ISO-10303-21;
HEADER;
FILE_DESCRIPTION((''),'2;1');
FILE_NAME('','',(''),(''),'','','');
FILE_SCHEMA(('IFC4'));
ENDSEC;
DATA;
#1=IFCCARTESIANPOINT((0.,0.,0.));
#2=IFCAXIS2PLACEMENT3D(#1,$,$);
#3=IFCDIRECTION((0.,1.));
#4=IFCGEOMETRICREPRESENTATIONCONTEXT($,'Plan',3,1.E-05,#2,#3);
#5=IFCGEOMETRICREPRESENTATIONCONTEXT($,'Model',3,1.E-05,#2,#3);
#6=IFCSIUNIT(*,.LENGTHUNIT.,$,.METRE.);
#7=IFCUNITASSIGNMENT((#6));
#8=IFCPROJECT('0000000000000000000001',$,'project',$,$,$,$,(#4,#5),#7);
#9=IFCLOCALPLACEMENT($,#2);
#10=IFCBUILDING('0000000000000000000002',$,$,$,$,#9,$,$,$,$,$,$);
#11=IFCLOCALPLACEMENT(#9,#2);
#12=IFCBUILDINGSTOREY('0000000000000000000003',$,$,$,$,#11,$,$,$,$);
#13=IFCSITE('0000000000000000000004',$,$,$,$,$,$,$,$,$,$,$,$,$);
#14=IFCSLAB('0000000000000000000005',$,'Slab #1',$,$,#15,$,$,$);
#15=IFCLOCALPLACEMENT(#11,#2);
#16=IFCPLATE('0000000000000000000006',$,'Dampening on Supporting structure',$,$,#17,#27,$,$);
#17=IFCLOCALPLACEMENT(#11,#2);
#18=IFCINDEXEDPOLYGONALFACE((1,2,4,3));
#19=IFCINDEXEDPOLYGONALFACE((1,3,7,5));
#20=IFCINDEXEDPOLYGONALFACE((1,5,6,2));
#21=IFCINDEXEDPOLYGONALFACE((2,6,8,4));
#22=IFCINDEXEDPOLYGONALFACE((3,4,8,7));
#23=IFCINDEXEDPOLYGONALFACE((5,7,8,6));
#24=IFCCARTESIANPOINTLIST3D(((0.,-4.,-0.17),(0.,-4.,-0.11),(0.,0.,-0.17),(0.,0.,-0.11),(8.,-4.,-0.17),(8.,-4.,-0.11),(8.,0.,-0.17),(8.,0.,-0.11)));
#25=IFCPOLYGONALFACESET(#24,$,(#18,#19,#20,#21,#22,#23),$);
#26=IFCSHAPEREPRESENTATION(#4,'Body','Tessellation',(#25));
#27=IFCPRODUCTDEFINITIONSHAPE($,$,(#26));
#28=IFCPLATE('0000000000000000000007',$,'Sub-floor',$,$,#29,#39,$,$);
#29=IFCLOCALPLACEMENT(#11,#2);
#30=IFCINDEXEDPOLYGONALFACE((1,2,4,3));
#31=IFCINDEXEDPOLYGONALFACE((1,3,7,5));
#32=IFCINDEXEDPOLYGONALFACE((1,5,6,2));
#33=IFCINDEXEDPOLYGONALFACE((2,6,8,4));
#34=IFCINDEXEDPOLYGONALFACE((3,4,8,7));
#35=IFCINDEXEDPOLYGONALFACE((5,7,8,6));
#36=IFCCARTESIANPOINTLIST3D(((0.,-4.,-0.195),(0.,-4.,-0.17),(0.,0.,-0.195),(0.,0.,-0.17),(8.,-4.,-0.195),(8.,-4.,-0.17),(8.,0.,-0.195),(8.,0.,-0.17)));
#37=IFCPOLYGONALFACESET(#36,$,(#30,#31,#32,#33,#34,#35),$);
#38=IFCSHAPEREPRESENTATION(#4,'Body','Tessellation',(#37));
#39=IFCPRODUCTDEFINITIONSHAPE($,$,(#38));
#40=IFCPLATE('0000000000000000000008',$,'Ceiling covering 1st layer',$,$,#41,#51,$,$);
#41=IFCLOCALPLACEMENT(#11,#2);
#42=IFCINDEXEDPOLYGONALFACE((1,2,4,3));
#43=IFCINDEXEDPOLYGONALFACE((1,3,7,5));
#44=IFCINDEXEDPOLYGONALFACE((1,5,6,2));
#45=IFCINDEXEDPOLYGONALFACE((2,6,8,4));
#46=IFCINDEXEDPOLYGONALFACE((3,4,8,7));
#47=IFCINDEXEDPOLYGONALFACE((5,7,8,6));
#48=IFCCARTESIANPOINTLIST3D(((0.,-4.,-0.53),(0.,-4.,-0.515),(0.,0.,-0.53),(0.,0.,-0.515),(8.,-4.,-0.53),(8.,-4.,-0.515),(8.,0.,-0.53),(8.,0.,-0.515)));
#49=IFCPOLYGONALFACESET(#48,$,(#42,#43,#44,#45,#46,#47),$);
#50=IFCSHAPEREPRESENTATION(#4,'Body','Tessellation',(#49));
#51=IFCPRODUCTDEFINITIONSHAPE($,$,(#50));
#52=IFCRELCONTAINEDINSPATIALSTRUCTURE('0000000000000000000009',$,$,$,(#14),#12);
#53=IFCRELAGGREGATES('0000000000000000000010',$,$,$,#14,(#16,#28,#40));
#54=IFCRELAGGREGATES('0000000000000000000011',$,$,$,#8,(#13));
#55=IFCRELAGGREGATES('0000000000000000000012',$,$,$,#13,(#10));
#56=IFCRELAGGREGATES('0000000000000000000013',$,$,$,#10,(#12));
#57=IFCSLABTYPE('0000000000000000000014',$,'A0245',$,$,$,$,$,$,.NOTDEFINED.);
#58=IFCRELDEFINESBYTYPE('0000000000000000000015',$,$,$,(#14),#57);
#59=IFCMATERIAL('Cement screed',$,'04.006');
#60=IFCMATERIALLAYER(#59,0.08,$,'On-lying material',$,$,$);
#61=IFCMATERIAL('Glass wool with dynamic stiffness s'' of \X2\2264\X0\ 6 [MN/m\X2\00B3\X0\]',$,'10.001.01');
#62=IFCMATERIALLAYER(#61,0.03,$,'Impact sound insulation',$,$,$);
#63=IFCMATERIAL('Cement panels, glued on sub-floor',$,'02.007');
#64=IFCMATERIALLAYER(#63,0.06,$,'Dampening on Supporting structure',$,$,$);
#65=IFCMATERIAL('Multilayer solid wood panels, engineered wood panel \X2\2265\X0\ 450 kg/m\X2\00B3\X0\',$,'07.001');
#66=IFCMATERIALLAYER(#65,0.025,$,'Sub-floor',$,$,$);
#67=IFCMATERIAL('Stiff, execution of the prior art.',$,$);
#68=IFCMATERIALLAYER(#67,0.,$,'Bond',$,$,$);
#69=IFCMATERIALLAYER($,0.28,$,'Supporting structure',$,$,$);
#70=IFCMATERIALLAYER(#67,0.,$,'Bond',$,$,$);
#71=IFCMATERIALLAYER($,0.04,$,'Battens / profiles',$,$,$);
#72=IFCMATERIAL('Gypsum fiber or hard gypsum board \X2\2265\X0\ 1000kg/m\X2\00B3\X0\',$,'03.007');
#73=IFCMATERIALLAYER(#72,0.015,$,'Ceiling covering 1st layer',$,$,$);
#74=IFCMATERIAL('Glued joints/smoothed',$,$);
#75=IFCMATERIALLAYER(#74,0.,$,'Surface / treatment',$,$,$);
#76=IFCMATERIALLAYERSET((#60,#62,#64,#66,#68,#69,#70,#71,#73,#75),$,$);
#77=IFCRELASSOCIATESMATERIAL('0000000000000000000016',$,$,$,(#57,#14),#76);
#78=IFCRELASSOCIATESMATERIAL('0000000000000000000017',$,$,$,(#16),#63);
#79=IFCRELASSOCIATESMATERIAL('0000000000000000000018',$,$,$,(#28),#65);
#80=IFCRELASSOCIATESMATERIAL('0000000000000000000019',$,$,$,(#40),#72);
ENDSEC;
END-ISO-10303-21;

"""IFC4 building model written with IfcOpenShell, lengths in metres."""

from ifc_helpers import new_model, si_unit, direction, frame, frame_2d, origin, place, context, project, spatial, rectangle, extrude, material, layer, layer_set, type_object, element, aggregate, save


model = new_model("IFC4")

# Units and contexts
plan_context = context("Plan", 3, precision=1e-05, world=origin(), true_north=direction((0.0, 1.0)))
model_context = context("Model", 3, precision=1e-05, world=origin(), true_north=direction((0.0, 1.0)))
ifc_project = project(units=[si_unit("LENGTHUNIT", "METRE")], contexts=[plan_context, model_context])

# Site, building, storey
site = spatial("IfcSite", under=ifc_project)
building_placement = place(None, origin())
building = spatial("IfcBuilding", under=site, at=building_placement)
storey_placement = place(building_placement, origin())
storey = spatial("IfcBuildingStorey", under=building, at=storey_placement)

# Slab, plates
ifc_material_1 = material(Name="Cement screed", Category="04.006")
ifc_layer_1 = layer(ifc_material_1, 0.08, Name="On-lying material")
ifc_material_2 = material(Name="Glass wool with dynamic stiffness s' of ≤ 6 [MN/m³]", Category="10.001.01")
ifc_layer_2 = layer(ifc_material_2, 0.03, Name="Impact sound insulation")
ifc_material_3 = material(Name="Cement panels, glued on sub-floor", Category="02.007")
ifc_layer_3 = layer(ifc_material_3, 0.06, Name="Dampening on Supporting structure")
ifc_material_4 = material(Name="Multilayer solid wood panels, engineered wood panel ≥ 450 kg/m³", Category="07.001")
ifc_layer_4 = layer(ifc_material_4, 0.025, Name="Sub-floor")
ifc_material_5 = material(Name="Stiff, execution of the prior art.")
ifc_layer_5 = layer(ifc_material_5, 0.0, Name="Bond")
ifc_layer_6 = layer(None, 0.28, Name="Supporting structure")
ifc_layer_7 = layer(ifc_material_5, 0.0, Name="Bond")
ifc_layer_8 = layer(None, 0.04, Name="Battens / profiles")
ifc_material_6 = material(Name="Gypsum fiber or hard gypsum board ≥ 1000kg/m³", Category="03.007")
ifc_layer_9 = layer(ifc_material_6, 0.015, Name="Ceiling covering 1st layer")
ifc_material_7 = material(Name="Glued joints/smoothed")
ifc_layer_10 = layer(ifc_material_7, 0.0, Name="Surface / treatment")
ifc_layer_set = layer_set([ifc_layer_1, ifc_layer_2, ifc_layer_3, ifc_layer_4, ifc_layer_5, ifc_layer_6, ifc_layer_7, ifc_layer_8, ifc_layer_9, ifc_layer_10])
slab_type = type_object("IfcSlabType", Name="A0245", PredefinedType="NOTDEFINED", material=ifc_layer_set)
slab_placement = place(None, frame((0.0, 0.0, 0.0), z_axis=(0.0, 0.0, -1.0), x_axis=(1.0, 0.0, 0.0)))
slab = element("IfcSlab", 1, at=slab_placement, inside=storey, type_object=slab_type, material=ifc_layer_set, Name="Slab #1")
plate_1_placement = place(slab_placement, origin())
plate_1 = element("IfcPlate", 2, at=plate_1_placement, material=ifc_material_3, Name="Dampening on Supporting structure", context=plan_context, shape_type="SweptSolid", body=[
    extrude(rectangle(XDim=8.0, YDim=4.0, at=frame_2d((4.0, 2.0), x_axis=(1.0, 0.0))), frame((0.0, 0.0, 0.11), z_axis=(0.0, 0.0, 1.0), x_axis=(1.0, 0.0, 0.0)), (0.0, 0.0, 1.0), 0.06),
])
plate_2_placement = place(slab_placement, origin())
plate_2 = element("IfcPlate", 3, at=plate_2_placement, material=ifc_material_4, Name="Sub-floor", context=plan_context, shape_type="SweptSolid", body=[
    extrude(rectangle(XDim=8.0, YDim=4.0, at=frame_2d((4.0, 2.0), x_axis=(1.0, 0.0))), frame((0.0, 0.0, 0.17), z_axis=(0.0, 0.0, 1.0), x_axis=(1.0, 0.0, 0.0)), (0.0, 0.0, 1.0), 0.025),
])
plate_3_placement = place(slab_placement, origin())
plate_3 = element("IfcPlate", 4, at=plate_3_placement, material=ifc_material_6, Name="Ceiling covering 1st layer", context=plan_context, shape_type="SweptSolid", body=[
    extrude(rectangle(XDim=8.0, YDim=4.0, at=frame_2d((4.0, 2.0), x_axis=(1.0, 0.0))), frame((0.0, 0.0, 0.515), z_axis=(0.0, 0.0, 1.0), x_axis=(1.0, 0.0, 0.0)), (0.0, 0.0, 1.0), 0.015),
])
aggregate(slab, [plate_1, plate_2, plate_3])

save(model, "model.ifc")
